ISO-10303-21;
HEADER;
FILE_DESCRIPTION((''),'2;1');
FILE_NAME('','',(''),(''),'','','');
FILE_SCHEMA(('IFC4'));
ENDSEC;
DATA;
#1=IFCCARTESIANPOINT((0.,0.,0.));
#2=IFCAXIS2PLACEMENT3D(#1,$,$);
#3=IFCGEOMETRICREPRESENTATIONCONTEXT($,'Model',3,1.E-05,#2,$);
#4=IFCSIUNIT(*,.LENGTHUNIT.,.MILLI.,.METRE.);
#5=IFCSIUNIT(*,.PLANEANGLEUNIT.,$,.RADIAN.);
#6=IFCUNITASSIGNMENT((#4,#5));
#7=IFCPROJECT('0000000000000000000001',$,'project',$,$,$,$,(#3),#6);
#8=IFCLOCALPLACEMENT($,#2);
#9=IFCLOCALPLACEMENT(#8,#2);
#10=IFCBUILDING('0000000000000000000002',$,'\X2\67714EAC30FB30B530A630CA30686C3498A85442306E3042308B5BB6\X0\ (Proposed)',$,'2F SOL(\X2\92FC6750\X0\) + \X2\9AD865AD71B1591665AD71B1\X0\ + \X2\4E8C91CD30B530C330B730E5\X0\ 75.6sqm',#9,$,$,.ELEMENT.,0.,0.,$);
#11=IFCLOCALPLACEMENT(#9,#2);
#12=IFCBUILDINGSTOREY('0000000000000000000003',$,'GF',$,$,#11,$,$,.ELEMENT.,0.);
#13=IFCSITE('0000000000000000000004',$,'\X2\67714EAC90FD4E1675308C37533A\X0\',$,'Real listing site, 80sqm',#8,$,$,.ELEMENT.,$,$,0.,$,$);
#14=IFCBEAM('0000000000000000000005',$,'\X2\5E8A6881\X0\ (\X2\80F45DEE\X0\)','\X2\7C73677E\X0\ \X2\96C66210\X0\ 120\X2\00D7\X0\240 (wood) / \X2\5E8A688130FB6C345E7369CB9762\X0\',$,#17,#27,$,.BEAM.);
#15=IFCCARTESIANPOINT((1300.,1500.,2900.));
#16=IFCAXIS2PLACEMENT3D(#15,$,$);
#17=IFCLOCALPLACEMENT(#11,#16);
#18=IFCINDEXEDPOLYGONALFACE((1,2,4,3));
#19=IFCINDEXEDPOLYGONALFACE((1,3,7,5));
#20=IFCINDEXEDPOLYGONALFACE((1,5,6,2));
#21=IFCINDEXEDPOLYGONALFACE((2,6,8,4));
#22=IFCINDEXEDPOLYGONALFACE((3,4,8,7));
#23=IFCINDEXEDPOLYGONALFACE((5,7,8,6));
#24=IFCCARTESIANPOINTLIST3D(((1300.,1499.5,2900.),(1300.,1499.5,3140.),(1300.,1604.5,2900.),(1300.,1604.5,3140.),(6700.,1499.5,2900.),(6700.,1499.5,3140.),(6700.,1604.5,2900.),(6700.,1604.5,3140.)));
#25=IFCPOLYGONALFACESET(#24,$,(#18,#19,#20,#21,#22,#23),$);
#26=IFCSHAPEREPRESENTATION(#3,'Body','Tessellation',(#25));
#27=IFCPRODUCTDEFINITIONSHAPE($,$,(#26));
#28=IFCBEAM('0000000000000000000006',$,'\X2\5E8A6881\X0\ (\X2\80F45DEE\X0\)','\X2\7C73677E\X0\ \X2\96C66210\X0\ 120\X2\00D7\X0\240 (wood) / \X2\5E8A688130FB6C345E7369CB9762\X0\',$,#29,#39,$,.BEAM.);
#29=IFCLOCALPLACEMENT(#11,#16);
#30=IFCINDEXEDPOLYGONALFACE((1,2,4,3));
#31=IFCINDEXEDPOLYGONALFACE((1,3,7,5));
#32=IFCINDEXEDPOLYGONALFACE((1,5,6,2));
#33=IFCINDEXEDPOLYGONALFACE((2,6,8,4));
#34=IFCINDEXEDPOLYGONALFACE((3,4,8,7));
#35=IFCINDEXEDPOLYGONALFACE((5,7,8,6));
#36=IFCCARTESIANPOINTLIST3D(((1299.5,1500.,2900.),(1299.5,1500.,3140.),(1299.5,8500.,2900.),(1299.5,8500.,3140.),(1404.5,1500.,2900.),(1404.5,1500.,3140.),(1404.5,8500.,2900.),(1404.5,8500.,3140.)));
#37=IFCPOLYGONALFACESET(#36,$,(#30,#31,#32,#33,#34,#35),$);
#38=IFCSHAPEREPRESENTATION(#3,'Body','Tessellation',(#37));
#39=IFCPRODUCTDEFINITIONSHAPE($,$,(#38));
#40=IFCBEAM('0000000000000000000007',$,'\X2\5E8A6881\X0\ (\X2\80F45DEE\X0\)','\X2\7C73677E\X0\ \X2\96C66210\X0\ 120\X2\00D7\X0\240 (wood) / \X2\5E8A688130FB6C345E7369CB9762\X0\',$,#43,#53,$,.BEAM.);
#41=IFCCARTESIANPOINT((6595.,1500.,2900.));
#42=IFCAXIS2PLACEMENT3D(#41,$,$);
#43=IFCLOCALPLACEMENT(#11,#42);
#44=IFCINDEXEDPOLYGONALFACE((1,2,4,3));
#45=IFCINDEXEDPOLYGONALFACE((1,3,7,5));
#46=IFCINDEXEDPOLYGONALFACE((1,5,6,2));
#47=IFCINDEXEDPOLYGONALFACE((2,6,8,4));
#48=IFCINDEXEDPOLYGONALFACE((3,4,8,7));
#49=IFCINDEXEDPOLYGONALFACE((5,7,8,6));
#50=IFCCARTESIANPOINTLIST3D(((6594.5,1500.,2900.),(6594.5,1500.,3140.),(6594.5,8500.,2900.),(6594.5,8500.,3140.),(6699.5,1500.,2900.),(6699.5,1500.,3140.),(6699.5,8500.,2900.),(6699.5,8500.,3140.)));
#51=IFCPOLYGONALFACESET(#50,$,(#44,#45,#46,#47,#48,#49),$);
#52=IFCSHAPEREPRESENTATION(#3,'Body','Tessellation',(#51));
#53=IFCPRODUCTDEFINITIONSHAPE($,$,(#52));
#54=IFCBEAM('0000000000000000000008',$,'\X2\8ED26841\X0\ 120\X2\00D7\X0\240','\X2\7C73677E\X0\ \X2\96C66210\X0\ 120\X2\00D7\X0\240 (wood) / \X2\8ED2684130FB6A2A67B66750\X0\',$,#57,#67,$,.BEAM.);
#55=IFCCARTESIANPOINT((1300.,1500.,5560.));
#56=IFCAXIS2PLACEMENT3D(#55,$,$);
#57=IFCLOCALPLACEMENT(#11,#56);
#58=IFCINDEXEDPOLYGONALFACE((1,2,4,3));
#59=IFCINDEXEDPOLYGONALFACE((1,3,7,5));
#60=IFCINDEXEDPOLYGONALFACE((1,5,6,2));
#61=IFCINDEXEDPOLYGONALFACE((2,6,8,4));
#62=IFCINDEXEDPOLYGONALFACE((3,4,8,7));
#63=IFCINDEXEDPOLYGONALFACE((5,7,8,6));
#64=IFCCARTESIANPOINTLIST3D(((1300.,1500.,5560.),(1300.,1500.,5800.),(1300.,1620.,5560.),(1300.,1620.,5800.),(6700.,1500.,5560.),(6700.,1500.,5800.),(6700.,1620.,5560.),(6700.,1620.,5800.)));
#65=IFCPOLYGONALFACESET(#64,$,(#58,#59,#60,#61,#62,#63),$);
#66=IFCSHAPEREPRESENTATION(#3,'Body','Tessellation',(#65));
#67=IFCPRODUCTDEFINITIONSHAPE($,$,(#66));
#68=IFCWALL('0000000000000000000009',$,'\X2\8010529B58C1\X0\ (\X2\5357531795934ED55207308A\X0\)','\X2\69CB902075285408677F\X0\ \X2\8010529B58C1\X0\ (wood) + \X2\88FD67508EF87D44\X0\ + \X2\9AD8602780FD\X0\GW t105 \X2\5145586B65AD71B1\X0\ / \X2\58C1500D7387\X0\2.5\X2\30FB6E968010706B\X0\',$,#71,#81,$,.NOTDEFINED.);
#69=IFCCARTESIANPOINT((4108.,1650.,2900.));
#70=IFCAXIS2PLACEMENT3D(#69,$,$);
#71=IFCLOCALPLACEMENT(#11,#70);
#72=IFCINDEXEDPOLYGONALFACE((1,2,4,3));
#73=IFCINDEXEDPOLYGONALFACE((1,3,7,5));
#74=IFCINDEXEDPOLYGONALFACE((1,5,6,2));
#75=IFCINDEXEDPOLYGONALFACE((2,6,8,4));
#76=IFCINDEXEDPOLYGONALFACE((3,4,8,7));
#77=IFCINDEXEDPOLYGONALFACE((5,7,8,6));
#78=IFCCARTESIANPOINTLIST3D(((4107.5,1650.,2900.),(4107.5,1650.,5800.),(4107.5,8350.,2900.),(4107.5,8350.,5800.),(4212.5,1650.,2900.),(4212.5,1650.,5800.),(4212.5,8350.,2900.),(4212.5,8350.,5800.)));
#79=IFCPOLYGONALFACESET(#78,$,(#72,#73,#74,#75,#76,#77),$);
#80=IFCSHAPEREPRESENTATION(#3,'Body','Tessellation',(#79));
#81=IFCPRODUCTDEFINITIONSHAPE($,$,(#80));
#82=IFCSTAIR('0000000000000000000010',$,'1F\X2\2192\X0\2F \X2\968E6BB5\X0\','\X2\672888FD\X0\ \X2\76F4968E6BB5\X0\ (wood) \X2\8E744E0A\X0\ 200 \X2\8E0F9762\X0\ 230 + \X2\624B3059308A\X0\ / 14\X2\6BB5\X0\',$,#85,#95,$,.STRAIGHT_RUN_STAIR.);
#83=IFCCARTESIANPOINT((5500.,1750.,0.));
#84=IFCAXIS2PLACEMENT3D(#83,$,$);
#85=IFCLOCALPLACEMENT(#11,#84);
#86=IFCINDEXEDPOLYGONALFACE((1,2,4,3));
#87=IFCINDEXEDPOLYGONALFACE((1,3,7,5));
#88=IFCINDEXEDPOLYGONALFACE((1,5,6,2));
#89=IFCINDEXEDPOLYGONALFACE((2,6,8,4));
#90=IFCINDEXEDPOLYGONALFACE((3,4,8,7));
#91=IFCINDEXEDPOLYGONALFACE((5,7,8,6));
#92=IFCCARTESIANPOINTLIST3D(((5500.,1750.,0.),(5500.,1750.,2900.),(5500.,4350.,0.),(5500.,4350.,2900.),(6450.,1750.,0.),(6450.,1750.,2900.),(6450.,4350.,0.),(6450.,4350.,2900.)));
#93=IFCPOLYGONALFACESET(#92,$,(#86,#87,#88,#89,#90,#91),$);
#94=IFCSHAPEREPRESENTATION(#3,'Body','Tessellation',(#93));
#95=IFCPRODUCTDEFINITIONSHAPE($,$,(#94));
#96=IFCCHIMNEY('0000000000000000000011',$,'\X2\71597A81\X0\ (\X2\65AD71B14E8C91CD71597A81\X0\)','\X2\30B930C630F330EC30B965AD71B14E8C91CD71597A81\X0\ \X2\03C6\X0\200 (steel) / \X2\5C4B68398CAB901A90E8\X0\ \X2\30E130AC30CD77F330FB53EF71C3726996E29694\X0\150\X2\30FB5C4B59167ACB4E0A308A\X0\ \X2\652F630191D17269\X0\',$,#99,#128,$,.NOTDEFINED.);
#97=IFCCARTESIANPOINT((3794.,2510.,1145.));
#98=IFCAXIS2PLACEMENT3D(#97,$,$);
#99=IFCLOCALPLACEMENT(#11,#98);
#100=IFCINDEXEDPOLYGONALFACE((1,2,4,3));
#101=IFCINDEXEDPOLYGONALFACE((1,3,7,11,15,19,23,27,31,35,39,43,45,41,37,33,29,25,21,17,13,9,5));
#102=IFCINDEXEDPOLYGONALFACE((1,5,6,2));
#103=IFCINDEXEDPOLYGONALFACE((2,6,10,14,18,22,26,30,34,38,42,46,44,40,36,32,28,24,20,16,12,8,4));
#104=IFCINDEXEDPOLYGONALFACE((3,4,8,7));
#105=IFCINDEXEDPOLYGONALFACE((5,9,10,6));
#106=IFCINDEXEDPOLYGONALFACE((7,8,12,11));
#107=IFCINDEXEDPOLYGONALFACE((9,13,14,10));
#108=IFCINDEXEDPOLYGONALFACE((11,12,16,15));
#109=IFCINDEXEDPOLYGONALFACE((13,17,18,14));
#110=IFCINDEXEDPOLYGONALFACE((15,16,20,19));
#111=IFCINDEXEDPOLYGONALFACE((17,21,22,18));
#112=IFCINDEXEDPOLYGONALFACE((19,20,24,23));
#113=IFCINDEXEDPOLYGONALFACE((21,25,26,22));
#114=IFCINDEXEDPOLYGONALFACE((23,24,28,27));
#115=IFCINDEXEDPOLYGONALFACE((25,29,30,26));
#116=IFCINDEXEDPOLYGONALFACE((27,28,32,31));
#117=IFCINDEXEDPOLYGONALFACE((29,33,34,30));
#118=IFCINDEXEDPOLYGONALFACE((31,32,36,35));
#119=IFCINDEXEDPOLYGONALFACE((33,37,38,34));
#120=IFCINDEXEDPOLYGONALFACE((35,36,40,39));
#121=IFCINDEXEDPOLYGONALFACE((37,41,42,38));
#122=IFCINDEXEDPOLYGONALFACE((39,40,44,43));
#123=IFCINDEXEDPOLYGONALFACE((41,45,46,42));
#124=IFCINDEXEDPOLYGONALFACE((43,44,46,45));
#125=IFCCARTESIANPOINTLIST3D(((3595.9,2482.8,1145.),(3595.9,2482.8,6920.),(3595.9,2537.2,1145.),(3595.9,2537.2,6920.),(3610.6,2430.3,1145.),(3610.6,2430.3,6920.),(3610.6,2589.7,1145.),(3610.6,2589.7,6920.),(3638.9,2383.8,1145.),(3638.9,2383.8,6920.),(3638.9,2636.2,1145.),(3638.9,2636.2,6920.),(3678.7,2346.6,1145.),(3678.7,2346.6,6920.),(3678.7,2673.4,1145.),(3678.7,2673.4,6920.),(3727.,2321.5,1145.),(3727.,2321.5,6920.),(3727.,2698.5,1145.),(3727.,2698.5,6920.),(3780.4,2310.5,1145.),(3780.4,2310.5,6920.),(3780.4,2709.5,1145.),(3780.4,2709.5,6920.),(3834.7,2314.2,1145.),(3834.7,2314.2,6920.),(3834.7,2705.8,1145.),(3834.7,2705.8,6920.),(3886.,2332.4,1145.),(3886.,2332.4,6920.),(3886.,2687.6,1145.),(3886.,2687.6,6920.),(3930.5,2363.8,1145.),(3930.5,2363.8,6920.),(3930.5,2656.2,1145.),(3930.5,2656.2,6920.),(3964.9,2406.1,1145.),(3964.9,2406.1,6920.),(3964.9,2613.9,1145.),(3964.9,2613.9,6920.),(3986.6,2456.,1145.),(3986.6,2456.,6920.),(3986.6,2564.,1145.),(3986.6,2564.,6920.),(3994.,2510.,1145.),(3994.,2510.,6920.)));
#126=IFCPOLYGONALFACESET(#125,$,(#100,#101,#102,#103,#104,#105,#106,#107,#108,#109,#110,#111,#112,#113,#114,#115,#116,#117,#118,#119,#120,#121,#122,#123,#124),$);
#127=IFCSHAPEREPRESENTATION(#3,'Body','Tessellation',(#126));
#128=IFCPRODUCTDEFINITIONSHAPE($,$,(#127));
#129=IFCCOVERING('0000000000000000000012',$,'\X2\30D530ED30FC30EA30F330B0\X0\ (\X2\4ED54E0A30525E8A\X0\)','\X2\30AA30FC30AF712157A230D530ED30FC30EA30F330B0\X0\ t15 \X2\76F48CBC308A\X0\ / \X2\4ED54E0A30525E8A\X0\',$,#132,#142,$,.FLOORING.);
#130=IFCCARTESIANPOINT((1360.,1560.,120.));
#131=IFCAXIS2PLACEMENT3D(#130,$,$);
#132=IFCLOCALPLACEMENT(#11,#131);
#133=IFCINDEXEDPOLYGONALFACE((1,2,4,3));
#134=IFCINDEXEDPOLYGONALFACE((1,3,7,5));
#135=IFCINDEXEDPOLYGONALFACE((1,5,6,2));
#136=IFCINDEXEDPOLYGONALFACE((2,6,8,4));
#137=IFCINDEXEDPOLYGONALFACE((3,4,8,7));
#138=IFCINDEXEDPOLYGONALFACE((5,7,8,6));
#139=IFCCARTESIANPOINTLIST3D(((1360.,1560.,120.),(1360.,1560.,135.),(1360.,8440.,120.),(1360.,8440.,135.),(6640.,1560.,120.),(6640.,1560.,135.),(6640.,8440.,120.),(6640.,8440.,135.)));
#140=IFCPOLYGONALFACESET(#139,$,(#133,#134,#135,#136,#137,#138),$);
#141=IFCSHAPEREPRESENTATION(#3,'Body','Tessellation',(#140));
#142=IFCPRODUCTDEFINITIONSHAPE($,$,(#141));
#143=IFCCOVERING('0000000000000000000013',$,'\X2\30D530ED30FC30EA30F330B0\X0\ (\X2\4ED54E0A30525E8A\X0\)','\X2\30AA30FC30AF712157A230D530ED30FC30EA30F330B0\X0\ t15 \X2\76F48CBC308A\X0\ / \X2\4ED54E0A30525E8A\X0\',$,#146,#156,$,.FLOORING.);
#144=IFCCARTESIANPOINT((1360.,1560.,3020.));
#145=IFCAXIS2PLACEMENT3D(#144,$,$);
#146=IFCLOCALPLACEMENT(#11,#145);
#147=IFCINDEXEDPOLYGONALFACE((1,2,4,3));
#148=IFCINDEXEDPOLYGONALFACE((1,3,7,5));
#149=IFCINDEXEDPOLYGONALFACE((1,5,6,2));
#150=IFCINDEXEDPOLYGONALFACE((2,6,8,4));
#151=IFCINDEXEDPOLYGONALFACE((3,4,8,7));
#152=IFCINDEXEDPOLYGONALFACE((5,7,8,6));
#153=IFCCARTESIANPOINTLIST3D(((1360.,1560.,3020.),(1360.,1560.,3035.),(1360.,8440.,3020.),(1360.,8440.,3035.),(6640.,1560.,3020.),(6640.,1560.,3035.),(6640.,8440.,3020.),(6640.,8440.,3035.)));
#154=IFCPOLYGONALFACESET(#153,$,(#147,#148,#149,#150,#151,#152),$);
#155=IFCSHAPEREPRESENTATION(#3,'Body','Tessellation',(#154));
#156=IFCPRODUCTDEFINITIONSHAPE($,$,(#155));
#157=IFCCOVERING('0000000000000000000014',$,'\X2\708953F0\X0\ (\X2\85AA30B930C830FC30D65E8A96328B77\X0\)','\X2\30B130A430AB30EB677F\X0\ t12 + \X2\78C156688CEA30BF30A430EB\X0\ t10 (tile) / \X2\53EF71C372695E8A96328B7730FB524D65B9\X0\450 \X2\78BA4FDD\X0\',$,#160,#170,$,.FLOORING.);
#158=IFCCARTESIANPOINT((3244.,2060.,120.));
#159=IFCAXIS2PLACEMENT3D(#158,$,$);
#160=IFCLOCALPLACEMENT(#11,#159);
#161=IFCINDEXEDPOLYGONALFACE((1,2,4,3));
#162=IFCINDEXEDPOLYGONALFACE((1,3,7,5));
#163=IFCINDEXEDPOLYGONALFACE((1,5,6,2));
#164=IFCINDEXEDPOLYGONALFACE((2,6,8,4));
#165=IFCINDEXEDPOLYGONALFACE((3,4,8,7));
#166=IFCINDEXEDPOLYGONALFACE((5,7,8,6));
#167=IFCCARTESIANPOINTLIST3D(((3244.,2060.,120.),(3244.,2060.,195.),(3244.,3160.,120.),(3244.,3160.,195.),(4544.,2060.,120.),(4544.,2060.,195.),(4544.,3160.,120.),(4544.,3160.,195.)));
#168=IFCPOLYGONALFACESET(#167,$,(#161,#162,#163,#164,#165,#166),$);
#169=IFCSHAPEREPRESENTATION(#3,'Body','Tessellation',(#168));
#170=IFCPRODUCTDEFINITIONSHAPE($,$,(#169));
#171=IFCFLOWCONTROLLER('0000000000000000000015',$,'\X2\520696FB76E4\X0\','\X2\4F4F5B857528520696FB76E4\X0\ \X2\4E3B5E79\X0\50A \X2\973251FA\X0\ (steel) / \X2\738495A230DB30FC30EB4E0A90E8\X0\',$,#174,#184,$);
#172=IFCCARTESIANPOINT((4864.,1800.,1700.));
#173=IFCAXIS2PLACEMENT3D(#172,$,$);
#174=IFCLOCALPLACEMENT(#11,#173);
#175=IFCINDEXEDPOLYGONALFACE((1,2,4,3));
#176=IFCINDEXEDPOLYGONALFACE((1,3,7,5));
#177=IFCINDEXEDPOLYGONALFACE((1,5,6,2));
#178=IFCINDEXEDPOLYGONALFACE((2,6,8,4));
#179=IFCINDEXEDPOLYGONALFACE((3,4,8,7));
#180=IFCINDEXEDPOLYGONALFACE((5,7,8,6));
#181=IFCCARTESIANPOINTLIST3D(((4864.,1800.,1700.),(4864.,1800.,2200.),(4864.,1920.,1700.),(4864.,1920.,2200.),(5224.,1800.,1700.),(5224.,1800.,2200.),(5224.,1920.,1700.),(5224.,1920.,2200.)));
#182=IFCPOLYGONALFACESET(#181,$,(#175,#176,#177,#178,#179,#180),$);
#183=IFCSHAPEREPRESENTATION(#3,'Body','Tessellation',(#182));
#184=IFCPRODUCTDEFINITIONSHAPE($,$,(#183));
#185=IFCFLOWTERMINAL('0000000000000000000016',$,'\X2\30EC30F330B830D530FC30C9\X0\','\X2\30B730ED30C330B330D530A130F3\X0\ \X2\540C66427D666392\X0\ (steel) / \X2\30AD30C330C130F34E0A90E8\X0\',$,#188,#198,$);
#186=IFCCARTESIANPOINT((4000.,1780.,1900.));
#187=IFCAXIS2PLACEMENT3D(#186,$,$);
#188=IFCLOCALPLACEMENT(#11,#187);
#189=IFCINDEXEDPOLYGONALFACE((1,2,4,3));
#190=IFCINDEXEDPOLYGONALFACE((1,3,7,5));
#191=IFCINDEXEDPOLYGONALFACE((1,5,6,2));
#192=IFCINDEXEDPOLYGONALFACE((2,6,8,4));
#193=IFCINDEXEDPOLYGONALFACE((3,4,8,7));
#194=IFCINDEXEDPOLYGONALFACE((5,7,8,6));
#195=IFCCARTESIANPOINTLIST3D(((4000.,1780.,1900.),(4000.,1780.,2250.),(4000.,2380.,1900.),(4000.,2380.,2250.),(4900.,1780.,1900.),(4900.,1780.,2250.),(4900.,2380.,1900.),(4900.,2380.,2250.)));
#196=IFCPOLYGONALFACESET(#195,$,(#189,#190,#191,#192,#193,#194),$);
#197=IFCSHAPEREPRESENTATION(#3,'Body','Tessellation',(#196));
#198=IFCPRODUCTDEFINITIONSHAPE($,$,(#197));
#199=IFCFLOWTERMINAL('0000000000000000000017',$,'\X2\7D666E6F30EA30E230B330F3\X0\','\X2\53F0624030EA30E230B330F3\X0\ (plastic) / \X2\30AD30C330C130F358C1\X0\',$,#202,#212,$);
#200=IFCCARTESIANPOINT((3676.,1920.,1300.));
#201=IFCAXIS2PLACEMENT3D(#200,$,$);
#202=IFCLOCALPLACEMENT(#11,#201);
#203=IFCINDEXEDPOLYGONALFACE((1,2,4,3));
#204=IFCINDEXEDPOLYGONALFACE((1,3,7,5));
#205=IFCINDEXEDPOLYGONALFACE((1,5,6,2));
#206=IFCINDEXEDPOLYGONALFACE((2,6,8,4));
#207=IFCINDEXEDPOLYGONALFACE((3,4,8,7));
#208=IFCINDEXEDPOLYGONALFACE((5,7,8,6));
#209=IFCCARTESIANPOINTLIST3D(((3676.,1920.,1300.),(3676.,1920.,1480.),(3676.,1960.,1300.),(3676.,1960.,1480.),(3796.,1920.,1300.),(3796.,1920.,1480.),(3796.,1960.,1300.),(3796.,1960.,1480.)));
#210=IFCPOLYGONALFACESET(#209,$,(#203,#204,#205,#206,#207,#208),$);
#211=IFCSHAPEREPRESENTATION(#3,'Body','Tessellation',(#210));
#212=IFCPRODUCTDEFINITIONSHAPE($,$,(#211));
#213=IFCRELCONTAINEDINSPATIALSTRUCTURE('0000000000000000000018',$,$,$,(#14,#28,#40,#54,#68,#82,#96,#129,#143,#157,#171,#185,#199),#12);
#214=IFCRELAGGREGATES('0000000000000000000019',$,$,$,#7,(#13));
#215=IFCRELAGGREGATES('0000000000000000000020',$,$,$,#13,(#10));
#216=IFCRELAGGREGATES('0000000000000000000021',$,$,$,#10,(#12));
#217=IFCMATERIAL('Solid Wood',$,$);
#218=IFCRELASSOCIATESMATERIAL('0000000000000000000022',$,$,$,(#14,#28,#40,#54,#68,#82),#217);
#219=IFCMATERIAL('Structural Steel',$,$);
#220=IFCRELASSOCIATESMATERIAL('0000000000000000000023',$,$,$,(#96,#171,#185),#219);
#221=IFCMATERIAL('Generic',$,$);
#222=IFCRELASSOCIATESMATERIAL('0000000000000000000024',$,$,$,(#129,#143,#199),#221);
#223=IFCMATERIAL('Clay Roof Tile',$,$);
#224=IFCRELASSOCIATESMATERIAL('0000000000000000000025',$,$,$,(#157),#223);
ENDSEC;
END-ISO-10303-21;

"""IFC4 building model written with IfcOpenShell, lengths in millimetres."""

from ifc_helpers import new_model, si_unit, frame, frame_2d, origin, origin_2d, place, context, project, spatial, rectangle, circle, extrude, material, element, save


model = new_model("IFC4")

# Units and contexts
model_context = context("Model", 3, precision=1e-05, world=origin())
ifc_project = project(units=[si_unit("LENGTHUNIT", "METRE", prefix="MILLI"), si_unit("PLANEANGLEUNIT", "RADIAN")], contexts=[model_context])

# Site, building, storey
site_placement = place(None, origin())
site = spatial("IfcSite", under=ifc_project, at=site_placement, Name="東京都世田谷区", ObjectType="Real listing site, 80sqm", CompositionType="ELEMENT", RefElevation=0.0)
building_placement = place(site_placement, origin())
building = spatial("IfcBuilding", under=site, at=building_placement, Name="東京・サウナと水風呂のある家 (Proposed)", ObjectType="2F SOL(鋼材) + 高断熱外断熱 + 二重サッシュ 75.6sqm", CompositionType="ELEMENT", ElevationOfRefHeight=0.0, ElevationOfTerrain=0.0)
storey_placement = place(building_placement, origin())
storey = spatial("IfcBuildingStorey", under=building, at=storey_placement, Name="GF", CompositionType="ELEMENT", Elevation=0.0)

# Beams
ifc_material_1 = material(Name="Solid Wood")
beam_1_placement = place(storey_placement, frame((1300.0, 1500.0, 2900.0)))
element("IfcBeam", 1, at=beam_1_placement, inside=storey, material=ifc_material_1, Name="床梁 (胴差)", Description="米松 集成 120×240 (wood) / 床梁・水平構面", PredefinedType="BEAM", context=model_context, shape_type="SweptSolid", body=[
    extrude(rectangle(XDim=5400.0, YDim=105.0, at=frame_2d((2700.0, 52.0))), frame((1300.0, 1500.0, 2900.0)), (0.0, 0.0, 1.0), 240.0),
])
beam_2_placement = place(storey_placement, frame((1300.0, 1500.0, 2900.0)))
element("IfcBeam", 2, at=beam_2_placement, inside=storey, material=ifc_material_1, Name="床梁 (胴差)", Description="米松 集成 120×240 (wood) / 床梁・水平構面", PredefinedType="BEAM", context=model_context, shape_type="SweptSolid", body=[
    extrude(rectangle(XDim=105.0, YDim=7000.0, at=frame_2d((52.0, 3500.0))), frame((1300.0, 1500.0, 2900.0)), (0.0, 0.0, 1.0), 240.0),
])
beam_3_placement = place(storey_placement, frame((6595.0, 1500.0, 2900.0)))
element("IfcBeam", 3, at=beam_3_placement, inside=storey, material=ifc_material_1, Name="床梁 (胴差)", Description="米松 集成 120×240 (wood) / 床梁・水平構面", PredefinedType="BEAM", context=model_context, shape_type="SweptSolid", body=[
    extrude(rectangle(XDim=105.0, YDim=7000.0, at=frame_2d((52.0, 3500.0))), frame((6595.0, 1500.0, 2900.0)), (0.0, 0.0, 1.0), 240.0),
])
beam_4_placement = place(storey_placement, frame((1300.0, 1500.0, 5560.0)))
element("IfcBeam", 4, at=beam_4_placement, inside=storey, material=ifc_material_1, Name="軒桁 120×240", Description="米松 集成 120×240 (wood) / 軒桁・横架材", PredefinedType="BEAM", context=model_context, shape_type="SweptSolid", body=[
    extrude(rectangle(XDim=5400.0, YDim=120.0, at=frame_2d((2700.0, 60.0))), frame((1300.0, 1500.0, 5560.0)), (0.0, 0.0, 1.0), 240.0),
])

# Wall
wall_1_placement = place(storey_placement, frame((4108.0, 1650.0, 2900.0)))
element("IfcWall", 5, at=wall_1_placement, inside=storey, material=ifc_material_1, Name="耐力壁 (南北間仕切り)", Description="構造用合板 耐力壁 (wood) + 製材軸組 + 高性能GW t105 充填断熱 / 壁倍率2.5・準耐火", PredefinedType="NOTDEFINED", context=model_context, shape_type="SweptSolid", body=[
    extrude(rectangle(XDim=105.0, YDim=6700.0, at=frame_2d((52.0, 3350.0))), frame((4108.0, 1650.0, 2900.0)), (0.0, 0.0, 1.0), 2900.0),
])

# Stair
stair_placement = place(storey_placement, frame((5500.0, 1750.0, 0.0)))
element("IfcStair", 6, at=stair_placement, inside=storey, material=ifc_material_1, Name="1F→2F 階段", Description="木製 直階段 (wood) 蹴上 200 踏面 230 + 手すり / 14段", PredefinedType="STRAIGHT_RUN_STAIR", context=model_context, shape_type="SweptSolid", body=[
    extrude(rectangle(XDim=950.0, YDim=2600.0, at=frame_2d((475.0, 1300.0))), frame((5500.0, 1750.0, 0.0)), (0.0, 0.0, 1.0), 2900.0),
])

# Chimney
ifc_material_2 = material(Name="Structural Steel")
chimney_placement = place(storey_placement, frame((3794.0, 2510.0, 1145.0)))
element("IfcChimney", 7, at=chimney_placement, inside=storey, material=ifc_material_2, Name="煙突 (断熱二重煙突)", Description="ステンレス断熱二重煙突 φ200 (steel) / 屋根貫通部 メガネ石・可燃物離隔150・屋外立上り 支持金物", PredefinedType="NOTDEFINED", context=model_context, shape_type="SweptSolid", body=[
    extrude(circle(Radius=200.0, at=origin_2d()), frame((3794.0, 2510.0, 1145.0)), (0.0, 0.0, 1.0), 5775.0),
])

# Coverings
ifc_material_3 = material(Name="Generic")
covering_1_placement = place(storey_placement, frame((1360.0, 1560.0, 120.0)))
element("IfcCovering", 8, at=covering_1_placement, inside=storey, material=ifc_material_3, Name="フローリング (仕上げ床)", Description="オーク無垢フローリング t15 直貼り / 仕上げ床", PredefinedType="FLOORING", context=model_context, shape_type="SweptSolid", body=[
    extrude(rectangle(XDim=5280.0, YDim=6880.0, at=frame_2d((2640.0, 3440.0))), frame((1360.0, 1560.0, 120.0)), (0.0, 0.0, 1.0), 15.0),
])
covering_2_placement = place(storey_placement, frame((1360.0, 1560.0, 3020.0)))
element("IfcCovering", 9, at=covering_2_placement, inside=storey, material=ifc_material_3, Name="フローリング (仕上げ床)", Description="オーク無垢フローリング t15 直貼り / 仕上げ床", PredefinedType="FLOORING", context=model_context, shape_type="SweptSolid", body=[
    extrude(rectangle(XDim=5280.0, YDim=6880.0, at=frame_2d((2640.0, 3440.0))), frame((1360.0, 1560.0, 3020.0)), (0.0, 0.0, 1.0), 15.0),
])
ifc_material_4 = material(Name="Clay Roof Tile")
covering_3_placement = place(storey_placement, frame((3244.0, 2060.0, 120.0)))
element("IfcCovering", 10, at=covering_3_placement, inside=storey, material=ifc_material_4, Name="炉台 (薪ストーブ床防護)", Description="ケイカル板 t12 + 磁器質タイル t10 (tile) / 可燃物床防護・前方450 確保", PredefinedType="FLOORING", context=model_context, shape_type="SweptSolid", body=[
    extrude(rectangle(XDim=1300.0, YDim=1100.0, at=frame_2d((650.0, 550.0))), frame((3244.0, 2060.0, 120.0)), (0.0, 0.0, 1.0), 75.0),
])

# Flow controller
flow_controller_placement = place(storey_placement, frame((4864.0, 1800.0, 1700.0)))
element("IfcFlowController", 11, at=flow_controller_placement, inside=storey, material=ifc_material_2, Name="分電盤", Description="住宅用分電盤 主幹50A 露出 (steel) / 玄関ホール上部", context=model_context, shape_type="SweptSolid", body=[
    extrude(rectangle(XDim=360.0, YDim=120.0, at=frame_2d((180.0, 60.0))), frame((4864.0, 1800.0, 1700.0)), (0.0, 0.0, 1.0), 500.0),
])

# Flow terminals
flow_terminal_1_placement = place(storey_placement, frame((4000.0, 1780.0, 1900.0)))
element("IfcFlowTerminal", 12, at=flow_terminal_1_placement, inside=storey, material=ifc_material_2, Name="レンジフード", Description="シロッコファン 同時給排 (steel) / キッチン上部", context=model_context, shape_type="SweptSolid", body=[
    extrude(rectangle(XDim=900.0, YDim=600.0, at=frame_2d((450.0, 300.0))), frame((4000.0, 1780.0, 1900.0)), (0.0, 0.0, 1.0), 350.0),
])
flow_terminal_2_placement = place(storey_placement, frame((3676.0, 1920.0, 1300.0)))
element("IfcFlowTerminal", 13, at=flow_terminal_2_placement, inside=storey, material=ifc_material_3, Name="給湯リモコン", Description="台所リモコン (plastic) / キッチン壁", context=model_context, shape_type="SweptSolid", body=[
    extrude(rectangle(XDim=120.0, YDim=40.0, at=frame_2d((60.0, 20.0))), frame((3676.0, 1920.0, 1300.0)), (0.0, 0.0, 1.0), 180.0),
])

save(model, "model.ifc")
